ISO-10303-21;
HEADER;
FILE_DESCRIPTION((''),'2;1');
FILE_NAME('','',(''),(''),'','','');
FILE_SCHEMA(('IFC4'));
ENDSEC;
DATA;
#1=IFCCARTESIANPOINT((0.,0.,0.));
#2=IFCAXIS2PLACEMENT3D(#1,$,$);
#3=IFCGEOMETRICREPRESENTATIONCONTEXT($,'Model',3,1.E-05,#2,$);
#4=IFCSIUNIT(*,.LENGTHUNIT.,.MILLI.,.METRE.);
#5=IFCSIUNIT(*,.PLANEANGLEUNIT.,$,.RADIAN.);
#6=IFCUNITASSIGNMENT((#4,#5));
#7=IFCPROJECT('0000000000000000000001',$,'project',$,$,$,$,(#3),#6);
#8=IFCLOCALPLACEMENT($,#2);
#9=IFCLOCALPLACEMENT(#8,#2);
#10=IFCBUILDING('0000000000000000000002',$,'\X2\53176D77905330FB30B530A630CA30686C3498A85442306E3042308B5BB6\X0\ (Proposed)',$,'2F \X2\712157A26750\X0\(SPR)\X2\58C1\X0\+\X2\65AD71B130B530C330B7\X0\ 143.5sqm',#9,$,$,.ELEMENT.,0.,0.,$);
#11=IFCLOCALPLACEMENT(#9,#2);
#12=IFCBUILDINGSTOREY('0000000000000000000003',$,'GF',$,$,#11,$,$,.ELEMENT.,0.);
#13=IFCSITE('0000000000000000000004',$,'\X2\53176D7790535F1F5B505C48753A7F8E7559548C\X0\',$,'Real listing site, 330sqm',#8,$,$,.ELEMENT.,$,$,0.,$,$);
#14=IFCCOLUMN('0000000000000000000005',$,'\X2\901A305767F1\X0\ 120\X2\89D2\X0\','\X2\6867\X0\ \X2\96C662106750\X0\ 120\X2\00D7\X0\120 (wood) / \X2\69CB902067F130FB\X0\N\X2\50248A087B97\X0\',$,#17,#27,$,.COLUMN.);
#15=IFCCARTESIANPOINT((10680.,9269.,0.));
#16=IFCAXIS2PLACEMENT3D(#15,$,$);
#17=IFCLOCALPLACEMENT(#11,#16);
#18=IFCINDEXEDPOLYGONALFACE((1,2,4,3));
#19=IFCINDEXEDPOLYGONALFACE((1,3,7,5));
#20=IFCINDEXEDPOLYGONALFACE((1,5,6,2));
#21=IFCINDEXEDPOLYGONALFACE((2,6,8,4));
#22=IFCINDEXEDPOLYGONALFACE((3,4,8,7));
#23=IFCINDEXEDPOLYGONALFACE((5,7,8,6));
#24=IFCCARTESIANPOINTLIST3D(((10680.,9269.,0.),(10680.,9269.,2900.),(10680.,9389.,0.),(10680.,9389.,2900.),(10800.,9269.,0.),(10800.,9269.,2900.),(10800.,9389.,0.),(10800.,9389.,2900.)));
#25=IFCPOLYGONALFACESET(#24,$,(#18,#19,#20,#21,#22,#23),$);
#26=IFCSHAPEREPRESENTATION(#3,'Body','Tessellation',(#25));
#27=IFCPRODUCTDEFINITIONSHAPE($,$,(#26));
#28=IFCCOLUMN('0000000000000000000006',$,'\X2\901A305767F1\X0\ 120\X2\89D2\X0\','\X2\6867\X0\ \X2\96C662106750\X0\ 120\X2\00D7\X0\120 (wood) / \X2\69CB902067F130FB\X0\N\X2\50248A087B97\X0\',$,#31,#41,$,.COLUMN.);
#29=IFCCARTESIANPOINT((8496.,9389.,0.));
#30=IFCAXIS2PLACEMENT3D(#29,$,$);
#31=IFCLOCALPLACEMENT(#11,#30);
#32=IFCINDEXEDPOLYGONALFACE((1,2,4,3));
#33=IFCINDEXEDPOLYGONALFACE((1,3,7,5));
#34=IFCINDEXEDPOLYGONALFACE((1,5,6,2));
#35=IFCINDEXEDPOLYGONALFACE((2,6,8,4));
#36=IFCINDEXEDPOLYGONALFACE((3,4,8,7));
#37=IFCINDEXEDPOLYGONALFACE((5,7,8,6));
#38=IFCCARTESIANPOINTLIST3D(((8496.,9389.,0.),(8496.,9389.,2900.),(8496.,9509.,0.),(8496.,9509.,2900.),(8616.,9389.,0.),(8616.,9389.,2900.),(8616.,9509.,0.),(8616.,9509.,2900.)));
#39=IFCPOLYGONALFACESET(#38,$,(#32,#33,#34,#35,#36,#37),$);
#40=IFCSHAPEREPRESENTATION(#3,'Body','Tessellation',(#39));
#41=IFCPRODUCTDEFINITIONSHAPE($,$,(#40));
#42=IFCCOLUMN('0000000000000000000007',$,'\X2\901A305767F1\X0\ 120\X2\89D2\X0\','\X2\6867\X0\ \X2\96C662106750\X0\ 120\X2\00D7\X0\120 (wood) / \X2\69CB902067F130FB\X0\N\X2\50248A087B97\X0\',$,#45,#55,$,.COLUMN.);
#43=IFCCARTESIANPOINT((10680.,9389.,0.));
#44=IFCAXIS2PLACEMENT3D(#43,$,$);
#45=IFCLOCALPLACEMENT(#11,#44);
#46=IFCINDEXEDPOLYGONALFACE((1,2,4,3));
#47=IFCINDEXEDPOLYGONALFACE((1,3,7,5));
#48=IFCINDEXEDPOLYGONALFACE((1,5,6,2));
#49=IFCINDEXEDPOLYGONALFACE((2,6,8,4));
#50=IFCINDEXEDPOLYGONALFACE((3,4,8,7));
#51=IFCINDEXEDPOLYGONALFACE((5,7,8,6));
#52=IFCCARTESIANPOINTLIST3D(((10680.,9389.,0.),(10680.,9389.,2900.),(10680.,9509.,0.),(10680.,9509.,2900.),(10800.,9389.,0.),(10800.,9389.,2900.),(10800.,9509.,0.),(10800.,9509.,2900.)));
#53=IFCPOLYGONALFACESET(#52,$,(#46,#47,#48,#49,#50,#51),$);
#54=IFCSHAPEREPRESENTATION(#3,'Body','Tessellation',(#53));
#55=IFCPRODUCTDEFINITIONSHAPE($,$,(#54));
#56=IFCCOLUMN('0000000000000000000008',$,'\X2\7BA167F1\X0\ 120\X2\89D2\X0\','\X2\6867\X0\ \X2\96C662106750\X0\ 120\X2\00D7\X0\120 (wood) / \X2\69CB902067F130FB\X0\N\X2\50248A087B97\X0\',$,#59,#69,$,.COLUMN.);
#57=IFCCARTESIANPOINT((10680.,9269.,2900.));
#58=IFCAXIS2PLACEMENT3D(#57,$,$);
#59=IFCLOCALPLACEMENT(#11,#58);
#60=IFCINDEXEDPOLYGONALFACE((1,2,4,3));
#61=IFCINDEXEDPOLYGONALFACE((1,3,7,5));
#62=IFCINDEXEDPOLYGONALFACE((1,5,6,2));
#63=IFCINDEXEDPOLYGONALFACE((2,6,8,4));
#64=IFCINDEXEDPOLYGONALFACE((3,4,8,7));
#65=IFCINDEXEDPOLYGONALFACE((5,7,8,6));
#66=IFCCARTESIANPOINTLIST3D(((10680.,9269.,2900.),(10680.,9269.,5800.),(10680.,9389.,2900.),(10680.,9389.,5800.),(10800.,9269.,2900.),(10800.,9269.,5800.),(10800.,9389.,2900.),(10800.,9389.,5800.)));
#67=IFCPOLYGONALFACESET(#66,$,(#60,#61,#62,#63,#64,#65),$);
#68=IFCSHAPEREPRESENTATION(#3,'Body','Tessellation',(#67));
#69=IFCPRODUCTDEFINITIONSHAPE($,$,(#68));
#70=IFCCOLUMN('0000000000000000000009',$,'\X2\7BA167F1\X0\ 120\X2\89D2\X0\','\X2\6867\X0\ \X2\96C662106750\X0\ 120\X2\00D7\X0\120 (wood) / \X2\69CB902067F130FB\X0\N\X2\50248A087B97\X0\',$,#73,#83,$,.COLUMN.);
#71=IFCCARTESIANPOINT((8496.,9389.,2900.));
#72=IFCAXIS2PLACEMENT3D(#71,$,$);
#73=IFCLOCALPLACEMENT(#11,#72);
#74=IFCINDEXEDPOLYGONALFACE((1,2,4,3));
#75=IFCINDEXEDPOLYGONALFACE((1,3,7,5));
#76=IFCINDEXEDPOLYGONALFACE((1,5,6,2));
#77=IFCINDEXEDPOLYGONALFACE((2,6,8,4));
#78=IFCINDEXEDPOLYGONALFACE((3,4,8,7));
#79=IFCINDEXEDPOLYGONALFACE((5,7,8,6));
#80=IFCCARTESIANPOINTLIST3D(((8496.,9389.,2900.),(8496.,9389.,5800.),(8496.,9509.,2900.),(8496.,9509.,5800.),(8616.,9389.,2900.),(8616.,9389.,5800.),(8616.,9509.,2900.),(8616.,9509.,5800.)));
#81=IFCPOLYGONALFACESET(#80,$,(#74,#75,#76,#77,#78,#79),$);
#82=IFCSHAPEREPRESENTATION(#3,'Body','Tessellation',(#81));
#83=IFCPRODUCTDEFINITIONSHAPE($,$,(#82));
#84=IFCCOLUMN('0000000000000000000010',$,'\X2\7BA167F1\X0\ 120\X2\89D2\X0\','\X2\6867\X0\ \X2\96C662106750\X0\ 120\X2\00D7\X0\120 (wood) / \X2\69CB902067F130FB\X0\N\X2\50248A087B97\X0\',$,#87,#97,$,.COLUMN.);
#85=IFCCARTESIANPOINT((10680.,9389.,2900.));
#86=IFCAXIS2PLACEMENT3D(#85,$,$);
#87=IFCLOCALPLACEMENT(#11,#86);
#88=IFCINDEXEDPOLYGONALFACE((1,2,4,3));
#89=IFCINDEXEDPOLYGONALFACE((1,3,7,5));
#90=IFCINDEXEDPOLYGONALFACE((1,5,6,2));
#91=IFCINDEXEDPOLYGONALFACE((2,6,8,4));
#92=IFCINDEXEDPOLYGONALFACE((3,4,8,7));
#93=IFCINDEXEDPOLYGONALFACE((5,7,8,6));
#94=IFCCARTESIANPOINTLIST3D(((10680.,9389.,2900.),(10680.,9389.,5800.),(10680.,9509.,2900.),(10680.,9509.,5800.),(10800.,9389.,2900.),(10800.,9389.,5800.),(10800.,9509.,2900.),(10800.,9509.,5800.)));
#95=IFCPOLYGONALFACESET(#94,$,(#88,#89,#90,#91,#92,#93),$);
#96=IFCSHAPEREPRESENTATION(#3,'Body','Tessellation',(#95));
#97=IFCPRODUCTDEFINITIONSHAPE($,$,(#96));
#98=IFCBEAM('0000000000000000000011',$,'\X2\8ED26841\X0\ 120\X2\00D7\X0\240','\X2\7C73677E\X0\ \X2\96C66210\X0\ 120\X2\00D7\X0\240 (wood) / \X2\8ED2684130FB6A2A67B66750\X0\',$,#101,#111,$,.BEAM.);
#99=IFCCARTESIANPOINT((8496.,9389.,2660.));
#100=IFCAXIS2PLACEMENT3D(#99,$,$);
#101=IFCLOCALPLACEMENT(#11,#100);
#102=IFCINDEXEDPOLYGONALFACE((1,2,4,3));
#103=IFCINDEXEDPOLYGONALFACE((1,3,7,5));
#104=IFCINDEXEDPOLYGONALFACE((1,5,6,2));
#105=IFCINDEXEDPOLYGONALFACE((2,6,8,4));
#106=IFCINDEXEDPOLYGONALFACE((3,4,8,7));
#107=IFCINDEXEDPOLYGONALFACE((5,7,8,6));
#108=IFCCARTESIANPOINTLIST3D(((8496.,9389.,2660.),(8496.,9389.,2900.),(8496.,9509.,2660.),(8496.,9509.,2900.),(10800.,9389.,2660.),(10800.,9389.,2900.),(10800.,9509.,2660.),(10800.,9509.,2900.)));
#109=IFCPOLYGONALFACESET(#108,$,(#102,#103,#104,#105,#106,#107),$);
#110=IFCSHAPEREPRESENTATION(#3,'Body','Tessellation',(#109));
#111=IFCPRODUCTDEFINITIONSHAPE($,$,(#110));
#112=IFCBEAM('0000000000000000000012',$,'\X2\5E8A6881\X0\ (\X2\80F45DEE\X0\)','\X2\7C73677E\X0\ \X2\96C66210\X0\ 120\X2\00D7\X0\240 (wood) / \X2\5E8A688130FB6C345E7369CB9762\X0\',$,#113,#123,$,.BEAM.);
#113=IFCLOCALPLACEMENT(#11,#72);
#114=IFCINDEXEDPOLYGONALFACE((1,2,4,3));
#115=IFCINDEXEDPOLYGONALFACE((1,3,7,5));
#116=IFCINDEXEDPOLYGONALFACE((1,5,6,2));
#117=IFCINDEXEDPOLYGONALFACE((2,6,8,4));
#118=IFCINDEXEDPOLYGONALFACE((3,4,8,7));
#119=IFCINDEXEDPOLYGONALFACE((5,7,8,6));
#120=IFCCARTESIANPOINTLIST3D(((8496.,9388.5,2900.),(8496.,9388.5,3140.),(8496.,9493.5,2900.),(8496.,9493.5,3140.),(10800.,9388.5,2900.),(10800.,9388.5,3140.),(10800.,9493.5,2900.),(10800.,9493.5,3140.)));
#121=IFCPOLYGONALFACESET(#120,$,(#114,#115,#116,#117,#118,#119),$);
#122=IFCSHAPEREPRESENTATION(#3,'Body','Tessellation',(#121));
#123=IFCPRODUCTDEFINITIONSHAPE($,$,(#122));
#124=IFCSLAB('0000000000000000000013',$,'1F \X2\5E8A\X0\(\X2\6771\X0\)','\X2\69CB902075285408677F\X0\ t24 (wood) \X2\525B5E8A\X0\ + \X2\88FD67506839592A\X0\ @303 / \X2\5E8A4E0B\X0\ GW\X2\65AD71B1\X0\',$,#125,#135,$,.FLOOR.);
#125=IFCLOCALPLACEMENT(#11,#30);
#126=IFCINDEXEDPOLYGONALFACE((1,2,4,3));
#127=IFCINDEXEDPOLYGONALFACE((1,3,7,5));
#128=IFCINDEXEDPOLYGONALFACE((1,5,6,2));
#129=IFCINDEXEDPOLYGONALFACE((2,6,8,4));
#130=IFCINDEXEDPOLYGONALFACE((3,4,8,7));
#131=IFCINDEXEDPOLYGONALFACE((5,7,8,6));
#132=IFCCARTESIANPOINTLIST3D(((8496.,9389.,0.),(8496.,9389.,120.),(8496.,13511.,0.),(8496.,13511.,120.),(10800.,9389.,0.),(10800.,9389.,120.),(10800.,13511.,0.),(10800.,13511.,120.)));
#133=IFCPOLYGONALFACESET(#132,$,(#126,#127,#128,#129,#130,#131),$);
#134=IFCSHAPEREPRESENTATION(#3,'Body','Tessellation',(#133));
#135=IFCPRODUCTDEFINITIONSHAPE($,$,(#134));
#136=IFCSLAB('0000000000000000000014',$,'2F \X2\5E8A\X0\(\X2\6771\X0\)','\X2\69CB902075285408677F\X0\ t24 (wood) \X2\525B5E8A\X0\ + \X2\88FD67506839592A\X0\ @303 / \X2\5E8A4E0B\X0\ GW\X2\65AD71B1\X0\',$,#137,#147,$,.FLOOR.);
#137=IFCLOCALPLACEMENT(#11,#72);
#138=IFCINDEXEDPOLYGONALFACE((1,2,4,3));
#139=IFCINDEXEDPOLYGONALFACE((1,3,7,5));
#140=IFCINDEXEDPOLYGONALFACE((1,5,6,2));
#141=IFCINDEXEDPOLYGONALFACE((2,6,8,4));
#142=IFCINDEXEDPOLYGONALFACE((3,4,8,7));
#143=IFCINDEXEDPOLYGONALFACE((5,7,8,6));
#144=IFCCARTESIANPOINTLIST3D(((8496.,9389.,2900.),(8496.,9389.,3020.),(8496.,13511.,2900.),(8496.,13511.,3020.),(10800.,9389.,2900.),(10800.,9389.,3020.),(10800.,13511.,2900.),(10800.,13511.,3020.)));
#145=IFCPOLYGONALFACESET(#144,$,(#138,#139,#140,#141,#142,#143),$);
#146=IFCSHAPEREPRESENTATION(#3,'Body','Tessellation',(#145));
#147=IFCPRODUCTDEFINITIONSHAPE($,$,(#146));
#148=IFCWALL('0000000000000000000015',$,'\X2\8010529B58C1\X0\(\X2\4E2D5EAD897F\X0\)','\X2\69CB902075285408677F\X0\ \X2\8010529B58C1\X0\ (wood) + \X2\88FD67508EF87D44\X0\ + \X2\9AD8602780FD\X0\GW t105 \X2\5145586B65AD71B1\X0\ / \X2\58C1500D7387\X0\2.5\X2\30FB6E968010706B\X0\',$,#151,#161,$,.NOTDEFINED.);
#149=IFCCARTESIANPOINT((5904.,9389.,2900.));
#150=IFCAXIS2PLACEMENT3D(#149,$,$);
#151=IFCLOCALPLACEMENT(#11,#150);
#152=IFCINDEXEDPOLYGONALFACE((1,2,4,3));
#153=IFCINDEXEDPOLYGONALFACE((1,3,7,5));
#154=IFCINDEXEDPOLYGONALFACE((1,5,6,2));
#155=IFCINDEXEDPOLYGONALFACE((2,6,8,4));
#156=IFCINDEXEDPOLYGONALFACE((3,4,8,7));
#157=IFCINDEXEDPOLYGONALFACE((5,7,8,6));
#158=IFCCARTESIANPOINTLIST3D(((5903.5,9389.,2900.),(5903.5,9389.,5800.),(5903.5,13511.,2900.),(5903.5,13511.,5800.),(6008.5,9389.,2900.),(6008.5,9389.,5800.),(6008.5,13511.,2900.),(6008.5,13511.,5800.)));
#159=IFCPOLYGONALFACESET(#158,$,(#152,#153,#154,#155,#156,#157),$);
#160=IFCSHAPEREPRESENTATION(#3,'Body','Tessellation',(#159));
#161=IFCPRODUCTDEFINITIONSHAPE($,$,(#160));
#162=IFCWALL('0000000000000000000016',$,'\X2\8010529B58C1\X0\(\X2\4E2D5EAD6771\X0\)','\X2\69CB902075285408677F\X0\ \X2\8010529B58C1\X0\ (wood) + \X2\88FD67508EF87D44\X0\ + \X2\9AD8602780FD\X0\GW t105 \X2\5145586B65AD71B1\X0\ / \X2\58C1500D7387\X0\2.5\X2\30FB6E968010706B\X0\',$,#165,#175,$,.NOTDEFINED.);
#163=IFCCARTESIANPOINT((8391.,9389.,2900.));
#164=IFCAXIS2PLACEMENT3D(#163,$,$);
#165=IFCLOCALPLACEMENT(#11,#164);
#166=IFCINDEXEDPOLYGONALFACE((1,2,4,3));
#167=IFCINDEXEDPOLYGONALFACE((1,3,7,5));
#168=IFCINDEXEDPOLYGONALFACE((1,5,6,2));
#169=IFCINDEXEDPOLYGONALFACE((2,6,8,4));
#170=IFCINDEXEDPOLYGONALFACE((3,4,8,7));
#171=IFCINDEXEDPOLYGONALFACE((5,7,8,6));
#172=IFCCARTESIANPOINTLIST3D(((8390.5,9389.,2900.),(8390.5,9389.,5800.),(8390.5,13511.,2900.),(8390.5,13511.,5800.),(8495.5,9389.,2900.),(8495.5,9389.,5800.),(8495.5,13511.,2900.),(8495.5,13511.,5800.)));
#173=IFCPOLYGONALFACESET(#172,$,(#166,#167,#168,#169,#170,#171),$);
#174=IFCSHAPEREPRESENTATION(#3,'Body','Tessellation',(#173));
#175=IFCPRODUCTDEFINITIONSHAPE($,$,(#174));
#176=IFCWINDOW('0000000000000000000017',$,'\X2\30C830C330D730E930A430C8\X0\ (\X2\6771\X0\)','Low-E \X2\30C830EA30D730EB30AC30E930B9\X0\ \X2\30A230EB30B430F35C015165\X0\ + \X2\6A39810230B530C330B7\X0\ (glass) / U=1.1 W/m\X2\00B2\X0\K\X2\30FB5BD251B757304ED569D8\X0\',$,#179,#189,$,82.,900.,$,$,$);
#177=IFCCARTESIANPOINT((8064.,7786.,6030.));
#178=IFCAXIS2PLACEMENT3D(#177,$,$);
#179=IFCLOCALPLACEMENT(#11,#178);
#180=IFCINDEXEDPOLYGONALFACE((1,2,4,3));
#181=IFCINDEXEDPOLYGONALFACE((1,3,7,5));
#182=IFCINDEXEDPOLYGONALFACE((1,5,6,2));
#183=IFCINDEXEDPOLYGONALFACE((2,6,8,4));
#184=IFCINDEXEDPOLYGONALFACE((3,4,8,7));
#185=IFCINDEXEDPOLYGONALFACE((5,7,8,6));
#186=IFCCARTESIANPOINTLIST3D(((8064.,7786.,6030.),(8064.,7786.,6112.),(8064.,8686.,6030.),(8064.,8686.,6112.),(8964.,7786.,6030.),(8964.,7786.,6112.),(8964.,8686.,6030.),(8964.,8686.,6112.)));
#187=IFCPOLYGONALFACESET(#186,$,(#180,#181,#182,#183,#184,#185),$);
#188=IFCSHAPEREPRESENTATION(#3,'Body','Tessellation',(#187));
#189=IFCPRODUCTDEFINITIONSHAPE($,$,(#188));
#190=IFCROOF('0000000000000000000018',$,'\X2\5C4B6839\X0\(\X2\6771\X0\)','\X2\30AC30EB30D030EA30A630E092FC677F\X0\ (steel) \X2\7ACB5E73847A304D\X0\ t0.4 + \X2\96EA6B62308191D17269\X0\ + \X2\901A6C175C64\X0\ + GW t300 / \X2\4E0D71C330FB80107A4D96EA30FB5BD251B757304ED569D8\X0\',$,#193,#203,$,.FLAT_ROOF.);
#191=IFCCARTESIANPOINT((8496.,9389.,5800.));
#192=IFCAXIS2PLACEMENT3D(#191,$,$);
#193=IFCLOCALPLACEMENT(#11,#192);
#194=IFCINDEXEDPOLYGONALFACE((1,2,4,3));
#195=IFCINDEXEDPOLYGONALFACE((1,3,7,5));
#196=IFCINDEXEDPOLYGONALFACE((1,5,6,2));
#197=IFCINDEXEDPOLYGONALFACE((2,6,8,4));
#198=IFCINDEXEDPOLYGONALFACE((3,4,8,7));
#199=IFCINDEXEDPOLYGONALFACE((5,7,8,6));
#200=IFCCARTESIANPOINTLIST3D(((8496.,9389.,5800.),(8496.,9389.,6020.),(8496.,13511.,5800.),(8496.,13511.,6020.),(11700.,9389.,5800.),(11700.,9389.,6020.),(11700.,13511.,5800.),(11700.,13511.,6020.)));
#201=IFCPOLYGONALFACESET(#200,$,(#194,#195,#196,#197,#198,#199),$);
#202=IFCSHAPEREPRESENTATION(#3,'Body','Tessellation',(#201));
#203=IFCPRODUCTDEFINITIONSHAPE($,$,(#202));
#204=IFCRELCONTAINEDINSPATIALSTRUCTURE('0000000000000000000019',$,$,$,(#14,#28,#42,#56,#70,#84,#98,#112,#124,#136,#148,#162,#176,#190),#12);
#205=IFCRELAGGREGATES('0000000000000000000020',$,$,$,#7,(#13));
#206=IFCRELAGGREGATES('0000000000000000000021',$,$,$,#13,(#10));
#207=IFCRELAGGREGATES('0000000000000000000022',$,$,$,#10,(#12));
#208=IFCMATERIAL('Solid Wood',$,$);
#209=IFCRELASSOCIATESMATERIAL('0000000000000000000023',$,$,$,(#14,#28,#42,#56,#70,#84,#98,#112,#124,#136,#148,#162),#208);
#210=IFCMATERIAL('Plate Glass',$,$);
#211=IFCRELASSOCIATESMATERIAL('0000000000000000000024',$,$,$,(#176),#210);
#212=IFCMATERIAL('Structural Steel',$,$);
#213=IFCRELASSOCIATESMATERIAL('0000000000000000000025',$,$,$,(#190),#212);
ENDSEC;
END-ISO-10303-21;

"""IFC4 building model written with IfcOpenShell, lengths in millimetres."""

from ifc_helpers import new_model, si_unit, frame, frame_2d, origin, place, context, project, spatial, rectangle, extrude, material, element, save


model = new_model("IFC4")

# Units and contexts
model_context = context("Model", 3, precision=1e-05, world=origin())
ifc_project = project(units=[si_unit("LENGTHUNIT", "METRE", prefix="MILLI"), si_unit("PLANEANGLEUNIT", "RADIAN")], contexts=[model_context])

# Site, building, storey
site_placement = place(None, origin())
site = spatial("IfcSite", under=ifc_project, at=site_placement, Name="北海道弟子屈町美留和", ObjectType="Real listing site, 330sqm", CompositionType="ELEMENT", RefElevation=0.0)
building_placement = place(site_placement, origin())
building = spatial("IfcBuilding", under=site, at=building_placement, Name="北海道・サウナと水風呂のある家 (Proposed)", ObjectType="2F 無垢材(SPR)壁+断熱サッシ 143.5sqm", CompositionType="ELEMENT", ElevationOfRefHeight=0.0, ElevationOfTerrain=0.0)
storey_placement = place(building_placement, origin())
storey = spatial("IfcBuildingStorey", under=building, at=storey_placement, Name="GF", CompositionType="ELEMENT", Elevation=0.0)

# Columns
ifc_material_1 = material(Name="Solid Wood")
column_1_placement = place(storey_placement, frame((10680.0, 9269.0, 0.0)))
element("IfcColumn", 1, at=column_1_placement, inside=storey, material=ifc_material_1, Name="通し柱 120角", Description="桧 集成材 120×120 (wood) / 構造柱・N値計算", PredefinedType="COLUMN", context=model_context, shape_type="SweptSolid", body=[
    extrude(rectangle(XDim=120.0, YDim=120.0, at=frame_2d((60.0, 60.0))), frame((10680.0, 9269.0, 0.0)), (0.0, 0.0, 1.0), 2900.0),
])
column_2_placement = place(storey_placement, frame((8496.0, 9389.0, 0.0)))
element("IfcColumn", 2, at=column_2_placement, inside=storey, material=ifc_material_1, Name="通し柱 120角", Description="桧 集成材 120×120 (wood) / 構造柱・N値計算", PredefinedType="COLUMN", context=model_context, shape_type="SweptSolid", body=[
    extrude(rectangle(XDim=120.0, YDim=120.0, at=frame_2d((60.0, 60.0))), frame((8496.0, 9389.0, 0.0)), (0.0, 0.0, 1.0), 2900.0),
])
column_3_placement = place(storey_placement, frame((10680.0, 9389.0, 0.0)))
element("IfcColumn", 3, at=column_3_placement, inside=storey, material=ifc_material_1, Name="通し柱 120角", Description="桧 集成材 120×120 (wood) / 構造柱・N値計算", PredefinedType="COLUMN", context=model_context, shape_type="SweptSolid", body=[
    extrude(rectangle(XDim=120.0, YDim=120.0, at=frame_2d((60.0, 60.0))), frame((10680.0, 9389.0, 0.0)), (0.0, 0.0, 1.0), 2900.0),
])
column_4_placement = place(storey_placement, frame((10680.0, 9269.0, 2900.0)))
element("IfcColumn", 4, at=column_4_placement, inside=storey, material=ifc_material_1, Name="管柱 120角", Description="桧 集成材 120×120 (wood) / 構造柱・N値計算", PredefinedType="COLUMN", context=model_context, shape_type="SweptSolid", body=[
    extrude(rectangle(XDim=120.0, YDim=120.0, at=frame_2d((60.0, 60.0))), frame((10680.0, 9269.0, 2900.0)), (0.0, 0.0, 1.0), 2900.0),
])
column_5_placement = place(storey_placement, frame((8496.0, 9389.0, 2900.0)))
element("IfcColumn", 5, at=column_5_placement, inside=storey, material=ifc_material_1, Name="管柱 120角", Description="桧 集成材 120×120 (wood) / 構造柱・N値計算", PredefinedType="COLUMN", context=model_context, shape_type="SweptSolid", body=[
    extrude(rectangle(XDim=120.0, YDim=120.0, at=frame_2d((60.0, 60.0))), frame((8496.0, 9389.0, 2900.0)), (0.0, 0.0, 1.0), 2900.0),
])
column_6_placement = place(storey_placement, frame((10680.0, 9389.0, 2900.0)))
element("IfcColumn", 6, at=column_6_placement, inside=storey, material=ifc_material_1, Name="管柱 120角", Description="桧 集成材 120×120 (wood) / 構造柱・N値計算", PredefinedType="COLUMN", context=model_context, shape_type="SweptSolid", body=[
    extrude(rectangle(XDim=120.0, YDim=120.0, at=frame_2d((60.0, 60.0))), frame((10680.0, 9389.0, 2900.0)), (0.0, 0.0, 1.0), 2900.0),
])

# Beams
beam_1_placement = place(storey_placement, frame((8496.0, 9389.0, 2660.0)))
element("IfcBeam", 7, at=beam_1_placement, inside=storey, material=ifc_material_1, Name="軒桁 120×240", Description="米松 集成 120×240 (wood) / 軒桁・横架材", PredefinedType="BEAM", context=model_context, shape_type="SweptSolid", body=[
    extrude(rectangle(XDim=2304.0, YDim=120.0, at=frame_2d((1152.0, 60.0))), frame((8496.0, 9389.0, 2660.0)), (0.0, 0.0, 1.0), 240.0),
])
beam_2_placement = place(storey_placement, frame((8496.0, 9389.0, 2900.0)))
element("IfcBeam", 8, at=beam_2_placement, inside=storey, material=ifc_material_1, Name="床梁 (胴差)", Description="米松 集成 120×240 (wood) / 床梁・水平構面", PredefinedType="BEAM", context=model_context, shape_type="SweptSolid", body=[
    extrude(rectangle(XDim=2304.0, YDim=105.0, at=frame_2d((1152.0, 52.0))), frame((8496.0, 9389.0, 2900.0)), (0.0, 0.0, 1.0), 240.0),
])

# Slabs
slab_1_placement = place(storey_placement, frame((8496.0, 9389.0, 0.0)))
element("IfcSlab", 9, at=slab_1_placement, inside=storey, material=ifc_material_1, Name="1F 床(東)", Description="構造用合板 t24 (wood) 剛床 + 製材根太 @303 / 床下 GW断熱", PredefinedType="FLOOR", context=model_context, shape_type="SweptSolid", body=[
    extrude(rectangle(XDim=2304.0, YDim=4122.0, at=frame_2d((1152.0, 2061.0))), frame((8496.0, 9389.0, 0.0)), (0.0, 0.0, 1.0), 120.0),
])
slab_2_placement = place(storey_placement, frame((8496.0, 9389.0, 2900.0)))
element("IfcSlab", 10, at=slab_2_placement, inside=storey, material=ifc_material_1, Name="2F 床(東)", Description="構造用合板 t24 (wood) 剛床 + 製材根太 @303 / 床下 GW断熱", PredefinedType="FLOOR", context=model_context, shape_type="SweptSolid", body=[
    extrude(rectangle(XDim=2304.0, YDim=4122.0, at=frame_2d((1152.0, 2061.0))), frame((8496.0, 9389.0, 2900.0)), (0.0, 0.0, 1.0), 120.0),
])

# Walls
wall_1_placement = place(storey_placement, frame((5904.0, 9389.0, 2900.0)))
element("IfcWall", 11, at=wall_1_placement, inside=storey, material=ifc_material_1, Name="耐力壁(中庭西)", Description="構造用合板 耐力壁 (wood) + 製材軸組 + 高性能GW t105 充填断熱 / 壁倍率2.5・準耐火", PredefinedType="NOTDEFINED", context=model_context, shape_type="SweptSolid", body=[
    extrude(rectangle(XDim=105.0, YDim=4122.0, at=frame_2d((52.0, 2061.0))), frame((5904.0, 9389.0, 2900.0)), (0.0, 0.0, 1.0), 2900.0),
])
wall_2_placement = place(storey_placement, frame((8391.0, 9389.0, 2900.0)))
element("IfcWall", 12, at=wall_2_placement, inside=storey, material=ifc_material_1, Name="耐力壁(中庭東)", Description="構造用合板 耐力壁 (wood) + 製材軸組 + 高性能GW t105 充填断熱 / 壁倍率2.5・準耐火", PredefinedType="NOTDEFINED", context=model_context, shape_type="SweptSolid", body=[
    extrude(rectangle(XDim=105.0, YDim=4122.0, at=frame_2d((52.0, 2061.0))), frame((8391.0, 9389.0, 2900.0)), (0.0, 0.0, 1.0), 2900.0),
])

# Window
ifc_material_2 = material(Name="Plate Glass")
window_placement = place(storey_placement, frame((8064.0, 7786.0, 6030.0)))
element("IfcWindow", 13, at=window_placement, inside=storey, material=ifc_material_2, Name="トップライト (東)", Description="Low-E トリプルガラス アルゴン封入 + 樹脂サッシ (glass) / U=1.1 W/m²K・寒冷地仕様", OverallHeight=82.0, OverallWidth=900.0, context=model_context, shape_type="SweptSolid", body=[
    extrude(rectangle(XDim=900.0, YDim=900.0, at=frame_2d((450.0, 450.0))), frame((8064.0, 7786.0, 6030.0)), (0.0, 0.0, 1.0), 82.0),
])

# Roof
ifc_material_3 = material(Name="Structural Steel")
for number, where, name in (
    (14, (8496.0, 9389.0, 5800.0), "屋根(東)"),
):
    element("IfcRoof", number, at=place(storey_placement, frame(where)), inside=storey, material=ifc_material_3, Name=name, Description="ガルバリウム鋼板 (steel) 立平葺き t0.4 + 雪止め金物 + 通気層 + GW t300 / 不燃・耐積雪・寒冷地仕様", PredefinedType="FLAT_ROOF", context=model_context, shape_type="SweptSolid", body=[
        extrude(rectangle(XDim=3204.0, YDim=4122.0, at=frame_2d((1602.0, 2061.0))), frame((8496.0, 9389.0, 5800.0)), (0.0, 0.0, 1.0), 220.0),
    ])

save(model, "model.ifc")
